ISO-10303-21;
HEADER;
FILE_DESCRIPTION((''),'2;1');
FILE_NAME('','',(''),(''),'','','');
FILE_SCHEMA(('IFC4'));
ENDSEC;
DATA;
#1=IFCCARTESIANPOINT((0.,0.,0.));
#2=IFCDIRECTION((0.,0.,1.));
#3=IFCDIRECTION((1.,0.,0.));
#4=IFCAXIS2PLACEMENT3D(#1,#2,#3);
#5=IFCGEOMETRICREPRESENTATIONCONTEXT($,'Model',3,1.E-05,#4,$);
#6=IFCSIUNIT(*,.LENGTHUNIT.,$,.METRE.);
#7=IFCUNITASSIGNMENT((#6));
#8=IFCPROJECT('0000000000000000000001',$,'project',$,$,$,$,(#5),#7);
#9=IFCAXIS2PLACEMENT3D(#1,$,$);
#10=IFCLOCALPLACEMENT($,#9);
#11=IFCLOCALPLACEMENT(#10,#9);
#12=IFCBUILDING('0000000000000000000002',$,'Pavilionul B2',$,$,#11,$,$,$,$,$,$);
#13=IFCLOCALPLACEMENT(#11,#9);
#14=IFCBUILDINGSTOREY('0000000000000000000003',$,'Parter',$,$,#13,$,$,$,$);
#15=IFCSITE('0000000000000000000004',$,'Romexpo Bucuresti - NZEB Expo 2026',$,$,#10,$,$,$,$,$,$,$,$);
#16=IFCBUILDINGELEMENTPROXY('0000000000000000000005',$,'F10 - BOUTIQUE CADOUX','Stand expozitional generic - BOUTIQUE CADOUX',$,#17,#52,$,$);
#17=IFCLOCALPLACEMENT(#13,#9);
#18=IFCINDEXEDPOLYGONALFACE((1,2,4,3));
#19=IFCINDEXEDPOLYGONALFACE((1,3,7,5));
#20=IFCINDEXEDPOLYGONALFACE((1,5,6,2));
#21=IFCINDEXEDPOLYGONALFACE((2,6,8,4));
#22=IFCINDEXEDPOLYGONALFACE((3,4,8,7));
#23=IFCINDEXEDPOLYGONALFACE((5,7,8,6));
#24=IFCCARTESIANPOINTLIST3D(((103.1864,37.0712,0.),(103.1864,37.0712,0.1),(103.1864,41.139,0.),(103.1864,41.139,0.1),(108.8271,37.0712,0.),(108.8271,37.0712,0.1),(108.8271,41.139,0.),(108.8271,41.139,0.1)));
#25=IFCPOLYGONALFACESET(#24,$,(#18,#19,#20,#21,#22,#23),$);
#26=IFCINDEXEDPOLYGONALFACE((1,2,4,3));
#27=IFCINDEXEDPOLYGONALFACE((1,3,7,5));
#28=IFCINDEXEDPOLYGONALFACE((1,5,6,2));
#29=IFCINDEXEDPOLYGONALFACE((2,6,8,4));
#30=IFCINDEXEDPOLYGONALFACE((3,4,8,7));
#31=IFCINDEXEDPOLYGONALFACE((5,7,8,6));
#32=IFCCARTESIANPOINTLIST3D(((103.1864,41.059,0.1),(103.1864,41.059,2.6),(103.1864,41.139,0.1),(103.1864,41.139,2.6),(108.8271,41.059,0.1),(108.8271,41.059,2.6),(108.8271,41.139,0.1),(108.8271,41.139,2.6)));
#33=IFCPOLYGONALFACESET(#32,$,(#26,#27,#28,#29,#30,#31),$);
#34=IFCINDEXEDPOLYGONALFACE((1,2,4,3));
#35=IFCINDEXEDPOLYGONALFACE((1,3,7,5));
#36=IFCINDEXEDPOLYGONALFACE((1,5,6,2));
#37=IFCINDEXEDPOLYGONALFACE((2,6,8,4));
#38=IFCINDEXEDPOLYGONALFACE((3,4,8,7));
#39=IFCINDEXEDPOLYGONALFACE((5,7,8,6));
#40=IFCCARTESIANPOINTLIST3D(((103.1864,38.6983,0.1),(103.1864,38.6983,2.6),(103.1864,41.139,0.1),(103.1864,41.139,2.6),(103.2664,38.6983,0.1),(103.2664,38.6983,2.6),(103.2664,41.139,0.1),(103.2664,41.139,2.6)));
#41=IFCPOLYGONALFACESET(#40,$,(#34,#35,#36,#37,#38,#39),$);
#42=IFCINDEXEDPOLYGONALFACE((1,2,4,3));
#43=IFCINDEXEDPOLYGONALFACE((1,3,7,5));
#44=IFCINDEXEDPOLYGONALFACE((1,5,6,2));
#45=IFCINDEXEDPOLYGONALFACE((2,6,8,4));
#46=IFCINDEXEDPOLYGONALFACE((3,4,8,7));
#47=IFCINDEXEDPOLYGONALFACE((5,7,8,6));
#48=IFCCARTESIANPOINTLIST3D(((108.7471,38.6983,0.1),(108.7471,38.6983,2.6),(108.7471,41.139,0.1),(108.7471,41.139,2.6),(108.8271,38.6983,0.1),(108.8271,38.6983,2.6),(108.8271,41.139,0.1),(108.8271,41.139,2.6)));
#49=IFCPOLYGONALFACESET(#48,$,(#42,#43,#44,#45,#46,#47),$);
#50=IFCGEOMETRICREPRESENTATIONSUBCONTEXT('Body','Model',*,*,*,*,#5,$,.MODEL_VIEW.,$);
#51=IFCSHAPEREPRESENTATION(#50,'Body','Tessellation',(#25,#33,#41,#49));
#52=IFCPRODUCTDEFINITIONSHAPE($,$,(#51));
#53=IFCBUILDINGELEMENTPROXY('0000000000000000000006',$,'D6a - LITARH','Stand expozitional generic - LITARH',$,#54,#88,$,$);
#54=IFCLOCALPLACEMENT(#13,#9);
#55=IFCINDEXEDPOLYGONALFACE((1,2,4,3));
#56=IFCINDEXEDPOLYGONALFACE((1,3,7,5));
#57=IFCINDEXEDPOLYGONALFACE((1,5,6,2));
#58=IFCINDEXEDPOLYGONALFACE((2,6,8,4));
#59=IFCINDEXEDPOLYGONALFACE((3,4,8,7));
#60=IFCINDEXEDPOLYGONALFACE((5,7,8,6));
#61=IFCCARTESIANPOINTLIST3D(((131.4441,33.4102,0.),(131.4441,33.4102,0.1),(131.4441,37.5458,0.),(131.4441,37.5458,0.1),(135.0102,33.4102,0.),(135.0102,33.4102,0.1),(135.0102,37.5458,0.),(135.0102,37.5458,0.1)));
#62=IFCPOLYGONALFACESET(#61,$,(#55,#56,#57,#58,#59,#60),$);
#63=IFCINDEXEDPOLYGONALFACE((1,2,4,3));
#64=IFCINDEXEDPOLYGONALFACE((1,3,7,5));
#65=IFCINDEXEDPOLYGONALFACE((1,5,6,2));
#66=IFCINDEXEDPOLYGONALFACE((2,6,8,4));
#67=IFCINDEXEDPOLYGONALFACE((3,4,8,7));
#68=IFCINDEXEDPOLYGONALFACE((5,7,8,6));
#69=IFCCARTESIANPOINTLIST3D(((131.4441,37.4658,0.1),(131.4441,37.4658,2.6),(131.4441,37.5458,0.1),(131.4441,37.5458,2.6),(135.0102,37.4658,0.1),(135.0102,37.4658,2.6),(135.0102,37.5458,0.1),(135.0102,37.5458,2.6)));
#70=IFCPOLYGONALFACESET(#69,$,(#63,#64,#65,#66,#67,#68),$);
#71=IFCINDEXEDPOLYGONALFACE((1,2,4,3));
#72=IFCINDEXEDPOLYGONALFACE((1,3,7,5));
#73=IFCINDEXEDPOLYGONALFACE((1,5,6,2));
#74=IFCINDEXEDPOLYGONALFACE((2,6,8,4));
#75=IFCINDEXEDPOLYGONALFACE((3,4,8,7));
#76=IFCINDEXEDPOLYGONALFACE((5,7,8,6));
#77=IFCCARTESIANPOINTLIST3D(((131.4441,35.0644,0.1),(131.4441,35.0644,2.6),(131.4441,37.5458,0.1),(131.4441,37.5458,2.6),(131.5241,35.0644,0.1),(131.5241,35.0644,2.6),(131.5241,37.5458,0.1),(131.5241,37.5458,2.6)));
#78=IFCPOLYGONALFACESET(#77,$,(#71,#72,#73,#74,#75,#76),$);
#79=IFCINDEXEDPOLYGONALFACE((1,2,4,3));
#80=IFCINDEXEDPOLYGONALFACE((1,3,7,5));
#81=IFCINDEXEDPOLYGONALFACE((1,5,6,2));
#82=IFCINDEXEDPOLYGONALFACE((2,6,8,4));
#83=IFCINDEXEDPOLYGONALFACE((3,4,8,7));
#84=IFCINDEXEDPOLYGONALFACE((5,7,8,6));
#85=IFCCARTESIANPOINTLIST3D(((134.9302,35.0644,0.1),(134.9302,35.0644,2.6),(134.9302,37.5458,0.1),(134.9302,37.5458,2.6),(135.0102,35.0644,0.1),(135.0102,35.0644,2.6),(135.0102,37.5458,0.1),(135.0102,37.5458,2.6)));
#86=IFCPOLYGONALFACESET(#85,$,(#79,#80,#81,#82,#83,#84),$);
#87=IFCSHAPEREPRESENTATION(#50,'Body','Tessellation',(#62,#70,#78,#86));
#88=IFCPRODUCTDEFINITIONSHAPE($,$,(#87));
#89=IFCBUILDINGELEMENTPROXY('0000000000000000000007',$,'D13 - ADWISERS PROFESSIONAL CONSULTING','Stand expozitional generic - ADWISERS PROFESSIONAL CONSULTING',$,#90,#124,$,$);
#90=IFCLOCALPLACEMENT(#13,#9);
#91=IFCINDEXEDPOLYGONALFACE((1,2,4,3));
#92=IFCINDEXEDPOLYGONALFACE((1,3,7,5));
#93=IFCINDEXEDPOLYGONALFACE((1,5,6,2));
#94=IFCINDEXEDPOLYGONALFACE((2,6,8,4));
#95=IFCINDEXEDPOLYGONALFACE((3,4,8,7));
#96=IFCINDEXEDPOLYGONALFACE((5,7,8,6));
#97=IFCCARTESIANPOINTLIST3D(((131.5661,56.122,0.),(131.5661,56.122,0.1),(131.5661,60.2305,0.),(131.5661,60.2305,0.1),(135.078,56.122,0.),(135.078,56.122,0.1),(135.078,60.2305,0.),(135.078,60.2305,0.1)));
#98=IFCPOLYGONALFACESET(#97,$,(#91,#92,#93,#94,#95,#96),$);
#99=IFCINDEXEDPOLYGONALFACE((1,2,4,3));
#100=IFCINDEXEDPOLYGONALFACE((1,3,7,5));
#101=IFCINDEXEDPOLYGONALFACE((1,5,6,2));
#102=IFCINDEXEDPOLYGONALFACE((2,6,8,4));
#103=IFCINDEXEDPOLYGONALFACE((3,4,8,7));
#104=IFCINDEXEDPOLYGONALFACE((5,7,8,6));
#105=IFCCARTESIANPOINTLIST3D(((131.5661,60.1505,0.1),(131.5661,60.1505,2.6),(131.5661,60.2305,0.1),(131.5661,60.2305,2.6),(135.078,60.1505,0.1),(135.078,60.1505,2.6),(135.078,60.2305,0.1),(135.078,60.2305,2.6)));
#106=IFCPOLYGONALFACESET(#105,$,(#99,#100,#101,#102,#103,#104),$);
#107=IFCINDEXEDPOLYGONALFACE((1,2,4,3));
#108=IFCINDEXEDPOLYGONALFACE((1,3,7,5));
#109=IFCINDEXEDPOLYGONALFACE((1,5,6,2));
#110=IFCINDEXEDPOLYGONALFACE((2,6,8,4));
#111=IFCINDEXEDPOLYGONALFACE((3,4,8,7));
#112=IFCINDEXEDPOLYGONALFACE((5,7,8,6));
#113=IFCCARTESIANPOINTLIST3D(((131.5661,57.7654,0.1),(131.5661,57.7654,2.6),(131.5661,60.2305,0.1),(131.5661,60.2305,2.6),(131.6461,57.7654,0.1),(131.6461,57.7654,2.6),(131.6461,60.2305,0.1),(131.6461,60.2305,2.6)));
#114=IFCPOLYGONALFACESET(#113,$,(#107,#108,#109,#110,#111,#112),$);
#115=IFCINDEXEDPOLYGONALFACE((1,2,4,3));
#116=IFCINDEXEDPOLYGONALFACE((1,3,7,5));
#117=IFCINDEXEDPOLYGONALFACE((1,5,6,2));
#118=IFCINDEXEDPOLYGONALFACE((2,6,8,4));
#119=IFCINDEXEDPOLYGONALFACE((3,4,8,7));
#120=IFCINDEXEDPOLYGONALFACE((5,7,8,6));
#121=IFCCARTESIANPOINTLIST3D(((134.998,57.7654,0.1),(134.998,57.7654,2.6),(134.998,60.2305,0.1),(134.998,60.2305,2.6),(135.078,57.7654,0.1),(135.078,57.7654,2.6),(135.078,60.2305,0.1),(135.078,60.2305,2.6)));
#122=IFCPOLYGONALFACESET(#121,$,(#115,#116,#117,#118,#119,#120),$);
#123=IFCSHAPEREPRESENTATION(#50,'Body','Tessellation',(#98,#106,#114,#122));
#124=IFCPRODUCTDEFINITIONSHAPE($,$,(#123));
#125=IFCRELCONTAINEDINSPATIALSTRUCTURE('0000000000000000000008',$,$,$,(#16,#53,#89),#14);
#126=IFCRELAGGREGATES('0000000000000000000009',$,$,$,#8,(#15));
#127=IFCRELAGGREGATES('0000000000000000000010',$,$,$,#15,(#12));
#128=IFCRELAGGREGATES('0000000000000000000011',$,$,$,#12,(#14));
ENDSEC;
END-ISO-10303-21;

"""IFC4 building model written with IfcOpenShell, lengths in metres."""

from ifc_helpers import new_model, si_unit, frame, frame_2d, origin, origin_with_axes, place, context, subcontext, project, spatial, rectangle, extrude, element, save


model = new_model("IFC4")

# Units and contexts
model_context = context("Model", 3, precision=1e-05, world=origin_with_axes())
body_context = subcontext(model_context, "Body", "Model", "MODEL_VIEW")
ifc_project = project(units=[si_unit("LENGTHUNIT", "METRE")], contexts=[model_context])

# Site, building, storey
site_placement = place(None, origin())
site = spatial("IfcSite", under=ifc_project, at=site_placement, Name="Romexpo Bucuresti - NZEB Expo 2026")
building_placement = place(site_placement, origin())
building = spatial("IfcBuilding", under=site, at=building_placement, Name="Pavilionul B2")
storey_placement = place(building_placement, origin())
storey = spatial("IfcBuildingStorey", under=building, at=storey_placement, Name="Parter")

# Building element proxies
for number, where, z_axis, x_axis, name in (
    (1, (103.1864, 37.0712, 0.0), (0.0, 0.0, 1.0), (1.0, 0.0, 0.0), "F10 - BOUTIQUE CADOUX"),
):
    element("IfcBuildingElementProxy", number, at=place(storey_placement, frame(where, z_axis=z_axis, x_axis=x_axis)), inside=storey, Name=name, Description="Stand expozitional generic - BOUTIQUE CADOUX", context=body_context, shape_type="SweptSolid", body=[
        extrude(rectangle(XDim=5.6407, YDim=4.0678, at=frame_2d((2.8203, 2.0339))), origin(), (0.0, 0.0, 1.0), 0.1),
        extrude(rectangle(XDim=5.6407, YDim=0.08, at=frame_2d((2.8203, 4.0278))), frame((0.0, 0.0, 0.1)), (0.0, 0.0, 1.0), 2.5),
        extrude(rectangle(XDim=0.08, YDim=2.4407, at=frame_2d((0.04, 2.8475))), frame((0.0, 0.0, 0.1)), (0.0, 0.0, 1.0), 2.5),
        extrude(rectangle(XDim=0.08, YDim=2.4407, at=frame_2d((5.6007, 2.8475))), frame((0.0, 0.0, 0.1)), (0.0, 0.0, 1.0), 2.5),
    ])
proxy_1_placement = place(storey_placement, frame((131.4441, 33.4102, 0.0), z_axis=(0.0, 0.0, 1.0), x_axis=(1.0, 0.0, 0.0)))
element("IfcBuildingElementProxy", 2, at=proxy_1_placement, inside=storey, Name="D6a - LITARH", Description="Stand expozitional generic - LITARH", context=body_context, shape_type="SweptSolid", body=[
    extrude(rectangle(XDim=3.5661, YDim=4.1356, at=frame_2d((1.7831, 2.0678))), origin(), (0.0, 0.0, 1.0), 0.1),
    extrude(rectangle(XDim=3.5661, YDim=0.08, at=frame_2d((1.7831, 4.0956))), frame((0.0, 0.0, 0.1)), (0.0, 0.0, 1.0), 2.5),
    extrude(rectangle(XDim=0.08, YDim=2.4814, at=frame_2d((0.04, 2.8949))), frame((0.0, 0.0, 0.1)), (0.0, 0.0, 1.0), 2.5),
    extrude(rectangle(XDim=0.08, YDim=2.4814, at=frame_2d((3.5261, 2.8949))), frame((0.0, 0.0, 0.1)), (0.0, 0.0, 1.0), 2.5),
])
proxy_2_placement = place(storey_placement, frame((131.5661, 56.122, 0.0), z_axis=(0.0, 0.0, 1.0), x_axis=(1.0, 0.0, 0.0)))
element("IfcBuildingElementProxy", 3, at=proxy_2_placement, inside=storey, Name="D13 - ADWISERS PROFESSIONAL CONSULTING", Description="Stand expozitional generic - ADWISERS PROFESSIONAL CONSULTING", context=body_context, shape_type="SweptSolid", body=[
    extrude(rectangle(XDim=3.5119, YDim=4.1085, at=frame_2d((1.7559, 2.0542))), origin(), (0.0, 0.0, 1.0), 0.1),
    extrude(rectangle(XDim=3.5119, YDim=0.08, at=frame_2d((1.7559, 4.0685))), frame((0.0, 0.0, 0.1)), (0.0, 0.0, 1.0), 2.5),
    extrude(rectangle(XDim=0.08, YDim=2.4651, at=frame_2d((0.04, 2.8759))), frame((0.0, 0.0, 0.1)), (0.0, 0.0, 1.0), 2.5),
    extrude(rectangle(XDim=0.08, YDim=2.4651, at=frame_2d((3.4719, 2.8759))), frame((0.0, 0.0, 0.1)), (0.0, 0.0, 1.0), 2.5),
])

save(model, "model.ifc")
